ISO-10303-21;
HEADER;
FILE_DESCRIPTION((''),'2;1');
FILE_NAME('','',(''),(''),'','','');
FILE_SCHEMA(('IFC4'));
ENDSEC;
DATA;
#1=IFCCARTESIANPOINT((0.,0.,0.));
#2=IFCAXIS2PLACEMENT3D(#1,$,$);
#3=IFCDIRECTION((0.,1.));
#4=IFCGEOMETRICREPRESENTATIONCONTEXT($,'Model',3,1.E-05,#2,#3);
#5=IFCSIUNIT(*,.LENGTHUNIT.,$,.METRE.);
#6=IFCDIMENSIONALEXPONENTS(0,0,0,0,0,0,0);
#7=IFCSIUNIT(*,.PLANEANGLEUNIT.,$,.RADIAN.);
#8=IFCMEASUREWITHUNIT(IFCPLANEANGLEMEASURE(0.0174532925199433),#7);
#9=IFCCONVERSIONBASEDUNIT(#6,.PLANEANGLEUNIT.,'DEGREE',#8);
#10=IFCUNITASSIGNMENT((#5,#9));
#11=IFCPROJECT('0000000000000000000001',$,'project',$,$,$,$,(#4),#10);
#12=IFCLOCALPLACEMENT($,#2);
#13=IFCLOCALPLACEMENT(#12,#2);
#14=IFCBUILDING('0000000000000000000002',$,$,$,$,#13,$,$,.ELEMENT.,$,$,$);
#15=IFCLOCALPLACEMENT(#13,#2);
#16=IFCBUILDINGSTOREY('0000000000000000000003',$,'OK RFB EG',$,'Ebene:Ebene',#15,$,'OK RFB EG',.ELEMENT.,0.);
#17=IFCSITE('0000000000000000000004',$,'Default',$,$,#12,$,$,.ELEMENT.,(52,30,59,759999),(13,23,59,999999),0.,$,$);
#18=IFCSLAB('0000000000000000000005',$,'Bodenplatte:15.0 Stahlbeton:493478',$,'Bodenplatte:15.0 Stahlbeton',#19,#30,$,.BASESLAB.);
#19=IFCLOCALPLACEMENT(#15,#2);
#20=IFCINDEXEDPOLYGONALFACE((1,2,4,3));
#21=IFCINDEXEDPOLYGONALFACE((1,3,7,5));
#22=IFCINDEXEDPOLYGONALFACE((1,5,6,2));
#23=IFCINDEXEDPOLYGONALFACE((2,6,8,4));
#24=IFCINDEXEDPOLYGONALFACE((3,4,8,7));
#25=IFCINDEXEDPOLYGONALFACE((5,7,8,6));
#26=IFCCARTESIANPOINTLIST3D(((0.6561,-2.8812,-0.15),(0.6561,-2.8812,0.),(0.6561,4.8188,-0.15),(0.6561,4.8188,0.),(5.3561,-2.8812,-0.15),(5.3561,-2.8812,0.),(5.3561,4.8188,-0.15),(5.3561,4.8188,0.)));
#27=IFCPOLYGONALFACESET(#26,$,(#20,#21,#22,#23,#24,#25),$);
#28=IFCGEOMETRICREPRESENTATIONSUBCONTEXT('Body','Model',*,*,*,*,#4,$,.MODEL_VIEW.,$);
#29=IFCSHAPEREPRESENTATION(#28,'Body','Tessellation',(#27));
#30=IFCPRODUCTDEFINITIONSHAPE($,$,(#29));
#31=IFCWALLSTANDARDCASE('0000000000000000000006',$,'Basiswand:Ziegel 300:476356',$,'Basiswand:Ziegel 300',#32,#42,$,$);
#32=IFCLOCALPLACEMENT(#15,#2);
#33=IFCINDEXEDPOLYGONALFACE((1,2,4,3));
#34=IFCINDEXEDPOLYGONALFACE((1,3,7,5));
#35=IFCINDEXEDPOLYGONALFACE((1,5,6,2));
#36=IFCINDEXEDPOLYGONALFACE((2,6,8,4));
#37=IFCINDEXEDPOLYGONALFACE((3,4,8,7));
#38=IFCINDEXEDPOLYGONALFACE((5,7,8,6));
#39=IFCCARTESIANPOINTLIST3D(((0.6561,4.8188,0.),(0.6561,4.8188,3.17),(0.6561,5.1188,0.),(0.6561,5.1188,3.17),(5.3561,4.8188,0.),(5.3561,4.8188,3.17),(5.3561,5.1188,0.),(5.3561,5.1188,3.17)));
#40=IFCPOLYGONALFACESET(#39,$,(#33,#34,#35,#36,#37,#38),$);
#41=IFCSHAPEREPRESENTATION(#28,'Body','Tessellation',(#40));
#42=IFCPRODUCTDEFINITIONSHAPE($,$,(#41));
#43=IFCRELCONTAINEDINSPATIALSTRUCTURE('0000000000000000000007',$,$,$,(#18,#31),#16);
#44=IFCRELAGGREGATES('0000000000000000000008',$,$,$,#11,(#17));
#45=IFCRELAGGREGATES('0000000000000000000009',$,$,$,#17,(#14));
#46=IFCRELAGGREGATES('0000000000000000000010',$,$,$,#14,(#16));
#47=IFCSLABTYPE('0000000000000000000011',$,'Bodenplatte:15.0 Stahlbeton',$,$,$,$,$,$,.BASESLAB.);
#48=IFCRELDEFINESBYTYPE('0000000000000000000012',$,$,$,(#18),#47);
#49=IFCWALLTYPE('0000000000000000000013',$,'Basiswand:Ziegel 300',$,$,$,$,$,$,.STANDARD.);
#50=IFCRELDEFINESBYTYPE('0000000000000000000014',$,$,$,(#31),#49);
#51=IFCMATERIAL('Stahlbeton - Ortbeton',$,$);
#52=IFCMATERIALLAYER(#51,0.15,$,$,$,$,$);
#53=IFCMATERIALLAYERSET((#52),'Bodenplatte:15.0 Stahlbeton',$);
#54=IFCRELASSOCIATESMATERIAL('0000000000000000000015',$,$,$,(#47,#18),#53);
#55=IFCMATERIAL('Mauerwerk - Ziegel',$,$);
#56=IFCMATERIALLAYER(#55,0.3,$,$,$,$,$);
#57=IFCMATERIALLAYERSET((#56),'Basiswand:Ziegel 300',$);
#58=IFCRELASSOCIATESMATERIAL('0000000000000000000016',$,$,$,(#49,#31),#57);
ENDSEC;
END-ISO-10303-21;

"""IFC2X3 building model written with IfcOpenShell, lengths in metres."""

from ifc_helpers import new_model, entity, si_unit, converted_unit, direction, frame, frame_2d, origin, place, context, subcontext, project, spatial, rectangle, extrude, material, layer, layer_set, layer_usage, type_object, element, save


model = new_model("IFC2X3")

# Units and contexts
model_context = context("Model", 3, precision=1e-05, world=origin(), true_north=direction((0.0, 1.0)))
body_context = subcontext(model_context, "Body", "Model", "MODEL_VIEW")
ifc_project = project(units=[si_unit("LENGTHUNIT", "METRE"), converted_unit("PLANEANGLEUNIT", "DEGREE", entity("IfcPlaneAngleMeasure", 0.0174532925199433), si_unit("PLANEANGLEUNIT", "RADIAN"), dimensions=[0, 0, 0, 0, 0, 0, 0])], contexts=[model_context])

# Site, building, storey
site_placement = place(None, origin())
site = spatial("IfcSite", under=ifc_project, at=site_placement, Name="Default", CompositionType="ELEMENT", RefLatitude=(52, 30, 59, 759999), RefLongitude=(13, 23, 59, 999999), RefElevation=0.0)
building_placement = place(site_placement, origin())
building = spatial("IfcBuilding", under=site, at=building_placement, CompositionType="ELEMENT")
storey_placement = place(building_placement, origin())
storey = spatial("IfcBuildingStorey", under=building, at=storey_placement, Name="OK RFB EG", ObjectType="Ebene:Ebene", LongName="OK RFB EG", CompositionType="ELEMENT", Elevation=0.0)

# Slab
ifc_material_1 = material(Name="Stahlbeton - Ortbeton")
ifc_layer_1 = layer(ifc_material_1, 0.15)
ifc_layer_set_1 = layer_set([ifc_layer_1], Name="Bodenplatte:15.0 Stahlbeton")
ifc_layer_usage_1 = layer_usage(ifc_layer_set_1, "AXIS3", "POSITIVE", 0.0)
slab_type = type_object("IfcSlabType", Name="Bodenplatte:15.0 Stahlbeton", PredefinedType="BASESLAB", material=ifc_layer_set_1)
slab_placement = place(storey_placement, origin())
element("IfcSlab", 1, at=slab_placement, inside=storey, type_object=slab_type, material=ifc_layer_usage_1, Name="Bodenplatte:15.0 Stahlbeton:493478", ObjectType="Bodenplatte:15.0 Stahlbeton", PredefinedType="BASESLAB", context=body_context, shape_type="SweptSolid", body=[
    extrude(rectangle(XDim=7.7, YDim=4.7, at=frame_2d((0.0, 0.0), x_axis=(1.0, 0.0))), frame((3.0061, 0.9688, 0.0), z_axis=(0.0, 0.0, -1.0), x_axis=(0.0, 1.0, 0.0)), (0.0, 0.0, 1.0), 0.15),
])

# Wall
ifc_material_2 = material(Name="Mauerwerk - Ziegel")
ifc_layer_2 = layer(ifc_material_2, 0.3)
ifc_layer_set_2 = layer_set([ifc_layer_2], Name="Basiswand:Ziegel 300")
ifc_layer_usage_2 = layer_usage(ifc_layer_set_2, "AXIS2", "NEGATIVE", 0.15)
wall_type = type_object("IfcWallType", Name="Basiswand:Ziegel 300", PredefinedType="STANDARD", material=ifc_layer_set_2)
wall_placement = place(storey_placement, frame((5.3561, 4.9688, 0.0), z_axis=(0.0, 0.0, 1.0), x_axis=(-1.0, 0.0, 0.0)))
element("IfcWallStandardCase", 2, at=wall_placement, inside=storey, type_object=wall_type, material=ifc_layer_usage_2, Name="Basiswand:Ziegel 300:476356", ObjectType="Basiswand:Ziegel 300", context=body_context, shape_type="SweptSolid", body=[
    extrude(rectangle(XDim=4.7, YDim=0.3, at=frame_2d((2.35, 0.0), x_axis=(-1.0, 0.0))), origin(), (0.0, 0.0, 1.0), 3.17),
])

save(model, "model.ifc")
